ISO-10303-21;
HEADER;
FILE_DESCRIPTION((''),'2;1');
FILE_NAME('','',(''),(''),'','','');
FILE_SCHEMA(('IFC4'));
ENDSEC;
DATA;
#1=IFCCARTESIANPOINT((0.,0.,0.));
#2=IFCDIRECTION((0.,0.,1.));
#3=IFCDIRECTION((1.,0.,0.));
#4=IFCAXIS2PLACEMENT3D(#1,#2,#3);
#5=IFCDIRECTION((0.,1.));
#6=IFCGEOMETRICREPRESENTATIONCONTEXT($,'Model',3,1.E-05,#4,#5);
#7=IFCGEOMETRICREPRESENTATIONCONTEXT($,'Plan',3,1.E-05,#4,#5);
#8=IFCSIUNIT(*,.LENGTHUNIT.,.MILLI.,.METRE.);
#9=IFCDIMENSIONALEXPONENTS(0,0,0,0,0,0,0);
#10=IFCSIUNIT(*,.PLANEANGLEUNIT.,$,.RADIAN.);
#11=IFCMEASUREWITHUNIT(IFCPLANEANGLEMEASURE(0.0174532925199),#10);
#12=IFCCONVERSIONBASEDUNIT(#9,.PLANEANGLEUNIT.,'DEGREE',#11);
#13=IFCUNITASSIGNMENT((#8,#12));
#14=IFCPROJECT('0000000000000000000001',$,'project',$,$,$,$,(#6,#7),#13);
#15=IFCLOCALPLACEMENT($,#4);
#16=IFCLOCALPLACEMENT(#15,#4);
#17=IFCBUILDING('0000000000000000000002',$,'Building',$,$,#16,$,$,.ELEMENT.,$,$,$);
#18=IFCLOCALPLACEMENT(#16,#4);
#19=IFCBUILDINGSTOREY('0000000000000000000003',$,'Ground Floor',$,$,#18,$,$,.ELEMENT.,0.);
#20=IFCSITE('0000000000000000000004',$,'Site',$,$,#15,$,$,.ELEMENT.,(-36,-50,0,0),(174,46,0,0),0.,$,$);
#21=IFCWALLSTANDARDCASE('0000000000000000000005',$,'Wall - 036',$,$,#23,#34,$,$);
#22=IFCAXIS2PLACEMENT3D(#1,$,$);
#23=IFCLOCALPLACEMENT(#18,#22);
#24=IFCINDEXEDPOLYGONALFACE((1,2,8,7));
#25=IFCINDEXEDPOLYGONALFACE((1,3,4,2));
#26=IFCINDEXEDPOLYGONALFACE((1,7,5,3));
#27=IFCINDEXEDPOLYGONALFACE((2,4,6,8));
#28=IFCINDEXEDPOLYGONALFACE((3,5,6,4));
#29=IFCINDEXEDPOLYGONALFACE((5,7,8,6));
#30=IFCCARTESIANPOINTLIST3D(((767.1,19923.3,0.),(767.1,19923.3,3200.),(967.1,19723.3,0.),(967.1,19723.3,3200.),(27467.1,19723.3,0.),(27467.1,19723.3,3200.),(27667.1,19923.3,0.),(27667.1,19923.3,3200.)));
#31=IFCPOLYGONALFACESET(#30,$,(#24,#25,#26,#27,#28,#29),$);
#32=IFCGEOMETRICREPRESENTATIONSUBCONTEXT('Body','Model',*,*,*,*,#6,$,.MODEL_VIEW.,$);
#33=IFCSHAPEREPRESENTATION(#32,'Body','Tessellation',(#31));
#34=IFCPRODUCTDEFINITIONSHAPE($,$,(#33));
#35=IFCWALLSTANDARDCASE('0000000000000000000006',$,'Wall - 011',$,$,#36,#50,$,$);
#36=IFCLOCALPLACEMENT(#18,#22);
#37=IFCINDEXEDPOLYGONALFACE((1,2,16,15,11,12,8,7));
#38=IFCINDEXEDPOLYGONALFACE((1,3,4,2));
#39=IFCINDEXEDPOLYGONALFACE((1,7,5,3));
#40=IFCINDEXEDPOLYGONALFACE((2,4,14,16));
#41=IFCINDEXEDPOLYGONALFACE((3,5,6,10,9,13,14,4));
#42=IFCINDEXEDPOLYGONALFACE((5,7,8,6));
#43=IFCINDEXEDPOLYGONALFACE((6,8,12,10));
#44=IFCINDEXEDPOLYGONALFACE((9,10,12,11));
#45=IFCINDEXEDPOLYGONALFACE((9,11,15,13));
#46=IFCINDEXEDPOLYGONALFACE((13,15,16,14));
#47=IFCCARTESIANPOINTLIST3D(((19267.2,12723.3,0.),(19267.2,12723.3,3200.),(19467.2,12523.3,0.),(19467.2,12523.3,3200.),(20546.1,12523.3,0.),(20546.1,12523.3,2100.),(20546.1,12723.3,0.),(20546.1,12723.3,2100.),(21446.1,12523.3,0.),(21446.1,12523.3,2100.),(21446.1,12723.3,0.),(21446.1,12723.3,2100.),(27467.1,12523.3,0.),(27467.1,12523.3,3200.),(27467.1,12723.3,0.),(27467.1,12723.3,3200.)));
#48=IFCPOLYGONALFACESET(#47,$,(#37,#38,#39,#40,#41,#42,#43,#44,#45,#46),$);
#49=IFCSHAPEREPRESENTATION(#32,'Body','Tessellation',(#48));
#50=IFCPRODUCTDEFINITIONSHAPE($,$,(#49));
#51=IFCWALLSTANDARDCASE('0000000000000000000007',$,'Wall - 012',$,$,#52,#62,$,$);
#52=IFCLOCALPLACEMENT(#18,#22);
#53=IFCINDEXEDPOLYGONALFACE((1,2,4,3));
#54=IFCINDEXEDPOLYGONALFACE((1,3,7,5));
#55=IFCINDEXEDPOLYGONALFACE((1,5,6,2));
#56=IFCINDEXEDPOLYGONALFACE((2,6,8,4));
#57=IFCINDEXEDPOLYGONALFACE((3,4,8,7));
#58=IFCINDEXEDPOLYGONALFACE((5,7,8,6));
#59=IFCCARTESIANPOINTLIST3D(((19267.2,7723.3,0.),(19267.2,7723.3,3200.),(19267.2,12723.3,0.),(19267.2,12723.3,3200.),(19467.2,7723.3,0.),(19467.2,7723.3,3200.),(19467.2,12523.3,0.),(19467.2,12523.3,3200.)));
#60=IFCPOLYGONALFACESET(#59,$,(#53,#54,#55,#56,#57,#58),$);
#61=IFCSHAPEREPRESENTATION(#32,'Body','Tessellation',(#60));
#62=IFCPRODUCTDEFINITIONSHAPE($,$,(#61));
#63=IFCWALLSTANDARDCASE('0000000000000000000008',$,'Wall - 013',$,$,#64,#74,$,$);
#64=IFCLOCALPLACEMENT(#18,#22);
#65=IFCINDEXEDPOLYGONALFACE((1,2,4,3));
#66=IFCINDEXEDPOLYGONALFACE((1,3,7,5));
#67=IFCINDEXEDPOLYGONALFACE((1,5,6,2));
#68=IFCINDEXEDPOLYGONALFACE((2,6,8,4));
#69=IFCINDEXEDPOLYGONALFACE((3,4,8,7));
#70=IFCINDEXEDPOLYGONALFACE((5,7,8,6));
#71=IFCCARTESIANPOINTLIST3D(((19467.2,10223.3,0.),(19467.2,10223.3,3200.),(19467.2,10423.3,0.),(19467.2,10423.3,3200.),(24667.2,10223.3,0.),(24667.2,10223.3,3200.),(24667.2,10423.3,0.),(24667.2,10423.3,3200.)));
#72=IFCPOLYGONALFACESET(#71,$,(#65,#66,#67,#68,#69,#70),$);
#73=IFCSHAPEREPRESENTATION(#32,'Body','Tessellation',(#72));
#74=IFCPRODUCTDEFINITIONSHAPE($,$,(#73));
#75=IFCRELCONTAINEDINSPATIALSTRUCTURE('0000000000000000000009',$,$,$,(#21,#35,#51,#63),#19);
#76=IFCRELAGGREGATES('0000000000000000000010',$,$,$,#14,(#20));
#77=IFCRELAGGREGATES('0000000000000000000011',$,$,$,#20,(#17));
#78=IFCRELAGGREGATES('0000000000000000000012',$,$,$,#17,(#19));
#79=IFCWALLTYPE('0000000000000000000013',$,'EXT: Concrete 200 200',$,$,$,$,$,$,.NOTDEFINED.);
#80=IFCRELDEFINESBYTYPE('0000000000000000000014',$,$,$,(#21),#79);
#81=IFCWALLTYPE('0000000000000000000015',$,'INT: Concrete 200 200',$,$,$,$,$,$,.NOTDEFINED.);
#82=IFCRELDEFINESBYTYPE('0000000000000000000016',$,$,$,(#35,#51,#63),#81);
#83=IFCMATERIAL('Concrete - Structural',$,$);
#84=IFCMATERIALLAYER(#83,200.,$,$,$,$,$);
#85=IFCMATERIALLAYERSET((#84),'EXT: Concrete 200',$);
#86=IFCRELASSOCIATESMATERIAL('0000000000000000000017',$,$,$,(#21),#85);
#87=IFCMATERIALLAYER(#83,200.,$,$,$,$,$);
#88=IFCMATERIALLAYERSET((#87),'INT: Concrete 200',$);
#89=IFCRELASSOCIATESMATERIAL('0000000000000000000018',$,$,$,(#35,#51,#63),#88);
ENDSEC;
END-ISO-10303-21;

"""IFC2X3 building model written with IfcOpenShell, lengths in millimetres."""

from ifc_helpers import new_model, entity, si_unit, converted_unit, direction, frame, origin_with_axes, origin_2d_with_axis, place, context, subcontext, project, spatial, polyline, rectangle, outline, extrude, material, layer, layer_set, layer_usage, type_object, element, save


model = new_model("IFC2X3")

# Units and contexts
model_context = context("Model", 3, precision=1e-05, world=origin_with_axes(), true_north=direction((0.0, 1.0)))
plan_context = context("Plan", 3, precision=1e-05, world=origin_with_axes(), true_north=direction((0.0, 1.0)))
body_context = subcontext(model_context, "Body", "Model", "MODEL_VIEW")
ifc_project = project(units=[si_unit("LENGTHUNIT", "METRE", prefix="MILLI"), converted_unit("PLANEANGLEUNIT", "DEGREE", entity("IfcPlaneAngleMeasure", 0.0174532925199), si_unit("PLANEANGLEUNIT", "RADIAN"), dimensions=[0, 0, 0, 0, 0, 0, 0])], contexts=[model_context, plan_context])

# Site, building, storey
site_placement = place(None, origin_with_axes())
site = spatial("IfcSite", under=ifc_project, at=site_placement, Name="Site", CompositionType="ELEMENT", RefLatitude=(-36, -50, 0, 0), RefLongitude=(174, 46, 0, 0), RefElevation=0.0)
building_placement = place(site_placement, origin_with_axes())
building = spatial("IfcBuilding", under=site, at=building_placement, Name="Building", CompositionType="ELEMENT")
storey_placement = place(building_placement, origin_with_axes())
storey = spatial("IfcBuildingStorey", under=building, at=storey_placement, Name="Ground Floor", CompositionType="ELEMENT", Elevation=0.0)

# Shared definitions
ifc_material_1 = material(Name="Concrete - Structural")

# Shared definitions
ifc_layer_1 = layer(ifc_material_1, 200.0)
ifc_layer_set_1 = layer_set([ifc_layer_1], Name="EXT: Concrete 200")
wall_type_1 = type_object("IfcWallType", Name="EXT: Concrete 200 200", PredefinedType="NOTDEFINED")

# Wall
ifc_layer_usage_1 = layer_usage(ifc_layer_set_1, "AXIS2", "POSITIVE", -200.0)
wall_1_placement = place(storey_placement, frame((767.1, 19923.3, 0.0), z_axis=(0.0, 0.0, 1.0), x_axis=(1.0, 0.0, 0.0)))
element("IfcWallStandardCase", 1, at=wall_1_placement, inside=storey, type_object=wall_type_1, material=ifc_layer_usage_1, Name="Wall - 036", context=body_context, shape_type="SweptSolid", body=[
    extrude(outline(polyline([(200.0, -200.0), (26700.0, -200.0), (26900.0, 0.0), (0.0, 0.0), (200.0, -200.0)])), origin_with_axes(), (0.0, 0.0, 1.0), 3200.0),
])

# Wall, opening
ifc_layer_2 = layer(ifc_material_1, 200.0)
ifc_layer_set_2 = layer_set([ifc_layer_2], Name="INT: Concrete 200")
ifc_layer_usage_2 = layer_usage(ifc_layer_set_2, "AXIS2", "POSITIVE", -200.0)
wall_type_2 = type_object("IfcWallType", Name="INT: Concrete 200 200", PredefinedType="NOTDEFINED")
wall_2_placement = place(storey_placement, frame((27667.1, 12523.3, 0.0), z_axis=(0.0, 0.0, 1.0), x_axis=(-1.0, 0.0, 0.0)))
wall_2 = element("IfcWallStandardCase", 2, at=wall_2_placement, inside=storey, type_object=wall_type_2, material=ifc_layer_usage_2, Name="Wall - 011", context=body_context, shape_type="SweptSolid", body=[
    extrude(outline(polyline([(200.0, -200.0), (8399.9, -200.0), (8199.9, 0.0), (200.0, 0.0), (200.0, -200.0)])), origin_with_axes(), (0.0, 0.0, 1.0), 3200.0),
])
opening_1_placement = place(wall_2_placement, frame((6671.0, 0.0, 0.0), z_axis=(0.0, 0.0, 1.0), x_axis=(1.0, 0.0, 0.0)))
element("IfcOpeningElement", 3, at=opening_1_placement, cuts=wall_2, context=body_context, shape_type="SweptSolid", body=[
    extrude(rectangle(XDim=900.0, YDim=2100.0, at=origin_2d_with_axis()), frame((0.0, -200.0, 1050.0), z_axis=(0.0, 1.0, 0.0), x_axis=(1.0, 0.0, 0.0)), (0.0, 0.0, 1.0), 600.0),
])

# Walls
ifc_layer_usage_3 = layer_usage(ifc_layer_set_2, "AXIS2", "POSITIVE", 0.0)
wall_3_placement = place(storey_placement, frame((19267.2, 12523.3, 0.0), z_axis=(0.0, 0.0, 1.0), x_axis=(0.0, -1.0, 0.0)))
element("IfcWallStandardCase", 4, at=wall_3_placement, inside=storey, type_object=wall_type_2, material=ifc_layer_usage_3, Name="Wall - 012", context=body_context, shape_type="SweptSolid", body=[
    extrude(outline(polyline([(-200.0, 0.0), (4800.0, 0.0), (4800.0, 200.0), (0.0, 200.0), (-200.0, 0.0)])), origin_with_axes(), (0.0, 0.0, 1.0), 3200.0),
])
ifc_layer_usage_4 = layer_usage(ifc_layer_set_2, "AXIS2", "POSITIVE", -200.0)
wall_4_placement = place(storey_placement, frame((19467.2, 10423.3, 0.0), z_axis=(0.0, 0.0, 1.0), x_axis=(1.0, 0.0, 0.0)))
element("IfcWallStandardCase", 5, at=wall_4_placement, inside=storey, type_object=wall_type_2, material=ifc_layer_usage_4, Name="Wall - 013", context=body_context, shape_type="SweptSolid", body=[
    extrude(outline(polyline([(0.0, -200.0), (5200.0, -200.0), (5200.0, 0.0), (0.0, 0.0), (0.0, -200.0)])), origin_with_axes(), (0.0, 0.0, 1.0), 3200.0),
])

save(model, "model.ifc")
